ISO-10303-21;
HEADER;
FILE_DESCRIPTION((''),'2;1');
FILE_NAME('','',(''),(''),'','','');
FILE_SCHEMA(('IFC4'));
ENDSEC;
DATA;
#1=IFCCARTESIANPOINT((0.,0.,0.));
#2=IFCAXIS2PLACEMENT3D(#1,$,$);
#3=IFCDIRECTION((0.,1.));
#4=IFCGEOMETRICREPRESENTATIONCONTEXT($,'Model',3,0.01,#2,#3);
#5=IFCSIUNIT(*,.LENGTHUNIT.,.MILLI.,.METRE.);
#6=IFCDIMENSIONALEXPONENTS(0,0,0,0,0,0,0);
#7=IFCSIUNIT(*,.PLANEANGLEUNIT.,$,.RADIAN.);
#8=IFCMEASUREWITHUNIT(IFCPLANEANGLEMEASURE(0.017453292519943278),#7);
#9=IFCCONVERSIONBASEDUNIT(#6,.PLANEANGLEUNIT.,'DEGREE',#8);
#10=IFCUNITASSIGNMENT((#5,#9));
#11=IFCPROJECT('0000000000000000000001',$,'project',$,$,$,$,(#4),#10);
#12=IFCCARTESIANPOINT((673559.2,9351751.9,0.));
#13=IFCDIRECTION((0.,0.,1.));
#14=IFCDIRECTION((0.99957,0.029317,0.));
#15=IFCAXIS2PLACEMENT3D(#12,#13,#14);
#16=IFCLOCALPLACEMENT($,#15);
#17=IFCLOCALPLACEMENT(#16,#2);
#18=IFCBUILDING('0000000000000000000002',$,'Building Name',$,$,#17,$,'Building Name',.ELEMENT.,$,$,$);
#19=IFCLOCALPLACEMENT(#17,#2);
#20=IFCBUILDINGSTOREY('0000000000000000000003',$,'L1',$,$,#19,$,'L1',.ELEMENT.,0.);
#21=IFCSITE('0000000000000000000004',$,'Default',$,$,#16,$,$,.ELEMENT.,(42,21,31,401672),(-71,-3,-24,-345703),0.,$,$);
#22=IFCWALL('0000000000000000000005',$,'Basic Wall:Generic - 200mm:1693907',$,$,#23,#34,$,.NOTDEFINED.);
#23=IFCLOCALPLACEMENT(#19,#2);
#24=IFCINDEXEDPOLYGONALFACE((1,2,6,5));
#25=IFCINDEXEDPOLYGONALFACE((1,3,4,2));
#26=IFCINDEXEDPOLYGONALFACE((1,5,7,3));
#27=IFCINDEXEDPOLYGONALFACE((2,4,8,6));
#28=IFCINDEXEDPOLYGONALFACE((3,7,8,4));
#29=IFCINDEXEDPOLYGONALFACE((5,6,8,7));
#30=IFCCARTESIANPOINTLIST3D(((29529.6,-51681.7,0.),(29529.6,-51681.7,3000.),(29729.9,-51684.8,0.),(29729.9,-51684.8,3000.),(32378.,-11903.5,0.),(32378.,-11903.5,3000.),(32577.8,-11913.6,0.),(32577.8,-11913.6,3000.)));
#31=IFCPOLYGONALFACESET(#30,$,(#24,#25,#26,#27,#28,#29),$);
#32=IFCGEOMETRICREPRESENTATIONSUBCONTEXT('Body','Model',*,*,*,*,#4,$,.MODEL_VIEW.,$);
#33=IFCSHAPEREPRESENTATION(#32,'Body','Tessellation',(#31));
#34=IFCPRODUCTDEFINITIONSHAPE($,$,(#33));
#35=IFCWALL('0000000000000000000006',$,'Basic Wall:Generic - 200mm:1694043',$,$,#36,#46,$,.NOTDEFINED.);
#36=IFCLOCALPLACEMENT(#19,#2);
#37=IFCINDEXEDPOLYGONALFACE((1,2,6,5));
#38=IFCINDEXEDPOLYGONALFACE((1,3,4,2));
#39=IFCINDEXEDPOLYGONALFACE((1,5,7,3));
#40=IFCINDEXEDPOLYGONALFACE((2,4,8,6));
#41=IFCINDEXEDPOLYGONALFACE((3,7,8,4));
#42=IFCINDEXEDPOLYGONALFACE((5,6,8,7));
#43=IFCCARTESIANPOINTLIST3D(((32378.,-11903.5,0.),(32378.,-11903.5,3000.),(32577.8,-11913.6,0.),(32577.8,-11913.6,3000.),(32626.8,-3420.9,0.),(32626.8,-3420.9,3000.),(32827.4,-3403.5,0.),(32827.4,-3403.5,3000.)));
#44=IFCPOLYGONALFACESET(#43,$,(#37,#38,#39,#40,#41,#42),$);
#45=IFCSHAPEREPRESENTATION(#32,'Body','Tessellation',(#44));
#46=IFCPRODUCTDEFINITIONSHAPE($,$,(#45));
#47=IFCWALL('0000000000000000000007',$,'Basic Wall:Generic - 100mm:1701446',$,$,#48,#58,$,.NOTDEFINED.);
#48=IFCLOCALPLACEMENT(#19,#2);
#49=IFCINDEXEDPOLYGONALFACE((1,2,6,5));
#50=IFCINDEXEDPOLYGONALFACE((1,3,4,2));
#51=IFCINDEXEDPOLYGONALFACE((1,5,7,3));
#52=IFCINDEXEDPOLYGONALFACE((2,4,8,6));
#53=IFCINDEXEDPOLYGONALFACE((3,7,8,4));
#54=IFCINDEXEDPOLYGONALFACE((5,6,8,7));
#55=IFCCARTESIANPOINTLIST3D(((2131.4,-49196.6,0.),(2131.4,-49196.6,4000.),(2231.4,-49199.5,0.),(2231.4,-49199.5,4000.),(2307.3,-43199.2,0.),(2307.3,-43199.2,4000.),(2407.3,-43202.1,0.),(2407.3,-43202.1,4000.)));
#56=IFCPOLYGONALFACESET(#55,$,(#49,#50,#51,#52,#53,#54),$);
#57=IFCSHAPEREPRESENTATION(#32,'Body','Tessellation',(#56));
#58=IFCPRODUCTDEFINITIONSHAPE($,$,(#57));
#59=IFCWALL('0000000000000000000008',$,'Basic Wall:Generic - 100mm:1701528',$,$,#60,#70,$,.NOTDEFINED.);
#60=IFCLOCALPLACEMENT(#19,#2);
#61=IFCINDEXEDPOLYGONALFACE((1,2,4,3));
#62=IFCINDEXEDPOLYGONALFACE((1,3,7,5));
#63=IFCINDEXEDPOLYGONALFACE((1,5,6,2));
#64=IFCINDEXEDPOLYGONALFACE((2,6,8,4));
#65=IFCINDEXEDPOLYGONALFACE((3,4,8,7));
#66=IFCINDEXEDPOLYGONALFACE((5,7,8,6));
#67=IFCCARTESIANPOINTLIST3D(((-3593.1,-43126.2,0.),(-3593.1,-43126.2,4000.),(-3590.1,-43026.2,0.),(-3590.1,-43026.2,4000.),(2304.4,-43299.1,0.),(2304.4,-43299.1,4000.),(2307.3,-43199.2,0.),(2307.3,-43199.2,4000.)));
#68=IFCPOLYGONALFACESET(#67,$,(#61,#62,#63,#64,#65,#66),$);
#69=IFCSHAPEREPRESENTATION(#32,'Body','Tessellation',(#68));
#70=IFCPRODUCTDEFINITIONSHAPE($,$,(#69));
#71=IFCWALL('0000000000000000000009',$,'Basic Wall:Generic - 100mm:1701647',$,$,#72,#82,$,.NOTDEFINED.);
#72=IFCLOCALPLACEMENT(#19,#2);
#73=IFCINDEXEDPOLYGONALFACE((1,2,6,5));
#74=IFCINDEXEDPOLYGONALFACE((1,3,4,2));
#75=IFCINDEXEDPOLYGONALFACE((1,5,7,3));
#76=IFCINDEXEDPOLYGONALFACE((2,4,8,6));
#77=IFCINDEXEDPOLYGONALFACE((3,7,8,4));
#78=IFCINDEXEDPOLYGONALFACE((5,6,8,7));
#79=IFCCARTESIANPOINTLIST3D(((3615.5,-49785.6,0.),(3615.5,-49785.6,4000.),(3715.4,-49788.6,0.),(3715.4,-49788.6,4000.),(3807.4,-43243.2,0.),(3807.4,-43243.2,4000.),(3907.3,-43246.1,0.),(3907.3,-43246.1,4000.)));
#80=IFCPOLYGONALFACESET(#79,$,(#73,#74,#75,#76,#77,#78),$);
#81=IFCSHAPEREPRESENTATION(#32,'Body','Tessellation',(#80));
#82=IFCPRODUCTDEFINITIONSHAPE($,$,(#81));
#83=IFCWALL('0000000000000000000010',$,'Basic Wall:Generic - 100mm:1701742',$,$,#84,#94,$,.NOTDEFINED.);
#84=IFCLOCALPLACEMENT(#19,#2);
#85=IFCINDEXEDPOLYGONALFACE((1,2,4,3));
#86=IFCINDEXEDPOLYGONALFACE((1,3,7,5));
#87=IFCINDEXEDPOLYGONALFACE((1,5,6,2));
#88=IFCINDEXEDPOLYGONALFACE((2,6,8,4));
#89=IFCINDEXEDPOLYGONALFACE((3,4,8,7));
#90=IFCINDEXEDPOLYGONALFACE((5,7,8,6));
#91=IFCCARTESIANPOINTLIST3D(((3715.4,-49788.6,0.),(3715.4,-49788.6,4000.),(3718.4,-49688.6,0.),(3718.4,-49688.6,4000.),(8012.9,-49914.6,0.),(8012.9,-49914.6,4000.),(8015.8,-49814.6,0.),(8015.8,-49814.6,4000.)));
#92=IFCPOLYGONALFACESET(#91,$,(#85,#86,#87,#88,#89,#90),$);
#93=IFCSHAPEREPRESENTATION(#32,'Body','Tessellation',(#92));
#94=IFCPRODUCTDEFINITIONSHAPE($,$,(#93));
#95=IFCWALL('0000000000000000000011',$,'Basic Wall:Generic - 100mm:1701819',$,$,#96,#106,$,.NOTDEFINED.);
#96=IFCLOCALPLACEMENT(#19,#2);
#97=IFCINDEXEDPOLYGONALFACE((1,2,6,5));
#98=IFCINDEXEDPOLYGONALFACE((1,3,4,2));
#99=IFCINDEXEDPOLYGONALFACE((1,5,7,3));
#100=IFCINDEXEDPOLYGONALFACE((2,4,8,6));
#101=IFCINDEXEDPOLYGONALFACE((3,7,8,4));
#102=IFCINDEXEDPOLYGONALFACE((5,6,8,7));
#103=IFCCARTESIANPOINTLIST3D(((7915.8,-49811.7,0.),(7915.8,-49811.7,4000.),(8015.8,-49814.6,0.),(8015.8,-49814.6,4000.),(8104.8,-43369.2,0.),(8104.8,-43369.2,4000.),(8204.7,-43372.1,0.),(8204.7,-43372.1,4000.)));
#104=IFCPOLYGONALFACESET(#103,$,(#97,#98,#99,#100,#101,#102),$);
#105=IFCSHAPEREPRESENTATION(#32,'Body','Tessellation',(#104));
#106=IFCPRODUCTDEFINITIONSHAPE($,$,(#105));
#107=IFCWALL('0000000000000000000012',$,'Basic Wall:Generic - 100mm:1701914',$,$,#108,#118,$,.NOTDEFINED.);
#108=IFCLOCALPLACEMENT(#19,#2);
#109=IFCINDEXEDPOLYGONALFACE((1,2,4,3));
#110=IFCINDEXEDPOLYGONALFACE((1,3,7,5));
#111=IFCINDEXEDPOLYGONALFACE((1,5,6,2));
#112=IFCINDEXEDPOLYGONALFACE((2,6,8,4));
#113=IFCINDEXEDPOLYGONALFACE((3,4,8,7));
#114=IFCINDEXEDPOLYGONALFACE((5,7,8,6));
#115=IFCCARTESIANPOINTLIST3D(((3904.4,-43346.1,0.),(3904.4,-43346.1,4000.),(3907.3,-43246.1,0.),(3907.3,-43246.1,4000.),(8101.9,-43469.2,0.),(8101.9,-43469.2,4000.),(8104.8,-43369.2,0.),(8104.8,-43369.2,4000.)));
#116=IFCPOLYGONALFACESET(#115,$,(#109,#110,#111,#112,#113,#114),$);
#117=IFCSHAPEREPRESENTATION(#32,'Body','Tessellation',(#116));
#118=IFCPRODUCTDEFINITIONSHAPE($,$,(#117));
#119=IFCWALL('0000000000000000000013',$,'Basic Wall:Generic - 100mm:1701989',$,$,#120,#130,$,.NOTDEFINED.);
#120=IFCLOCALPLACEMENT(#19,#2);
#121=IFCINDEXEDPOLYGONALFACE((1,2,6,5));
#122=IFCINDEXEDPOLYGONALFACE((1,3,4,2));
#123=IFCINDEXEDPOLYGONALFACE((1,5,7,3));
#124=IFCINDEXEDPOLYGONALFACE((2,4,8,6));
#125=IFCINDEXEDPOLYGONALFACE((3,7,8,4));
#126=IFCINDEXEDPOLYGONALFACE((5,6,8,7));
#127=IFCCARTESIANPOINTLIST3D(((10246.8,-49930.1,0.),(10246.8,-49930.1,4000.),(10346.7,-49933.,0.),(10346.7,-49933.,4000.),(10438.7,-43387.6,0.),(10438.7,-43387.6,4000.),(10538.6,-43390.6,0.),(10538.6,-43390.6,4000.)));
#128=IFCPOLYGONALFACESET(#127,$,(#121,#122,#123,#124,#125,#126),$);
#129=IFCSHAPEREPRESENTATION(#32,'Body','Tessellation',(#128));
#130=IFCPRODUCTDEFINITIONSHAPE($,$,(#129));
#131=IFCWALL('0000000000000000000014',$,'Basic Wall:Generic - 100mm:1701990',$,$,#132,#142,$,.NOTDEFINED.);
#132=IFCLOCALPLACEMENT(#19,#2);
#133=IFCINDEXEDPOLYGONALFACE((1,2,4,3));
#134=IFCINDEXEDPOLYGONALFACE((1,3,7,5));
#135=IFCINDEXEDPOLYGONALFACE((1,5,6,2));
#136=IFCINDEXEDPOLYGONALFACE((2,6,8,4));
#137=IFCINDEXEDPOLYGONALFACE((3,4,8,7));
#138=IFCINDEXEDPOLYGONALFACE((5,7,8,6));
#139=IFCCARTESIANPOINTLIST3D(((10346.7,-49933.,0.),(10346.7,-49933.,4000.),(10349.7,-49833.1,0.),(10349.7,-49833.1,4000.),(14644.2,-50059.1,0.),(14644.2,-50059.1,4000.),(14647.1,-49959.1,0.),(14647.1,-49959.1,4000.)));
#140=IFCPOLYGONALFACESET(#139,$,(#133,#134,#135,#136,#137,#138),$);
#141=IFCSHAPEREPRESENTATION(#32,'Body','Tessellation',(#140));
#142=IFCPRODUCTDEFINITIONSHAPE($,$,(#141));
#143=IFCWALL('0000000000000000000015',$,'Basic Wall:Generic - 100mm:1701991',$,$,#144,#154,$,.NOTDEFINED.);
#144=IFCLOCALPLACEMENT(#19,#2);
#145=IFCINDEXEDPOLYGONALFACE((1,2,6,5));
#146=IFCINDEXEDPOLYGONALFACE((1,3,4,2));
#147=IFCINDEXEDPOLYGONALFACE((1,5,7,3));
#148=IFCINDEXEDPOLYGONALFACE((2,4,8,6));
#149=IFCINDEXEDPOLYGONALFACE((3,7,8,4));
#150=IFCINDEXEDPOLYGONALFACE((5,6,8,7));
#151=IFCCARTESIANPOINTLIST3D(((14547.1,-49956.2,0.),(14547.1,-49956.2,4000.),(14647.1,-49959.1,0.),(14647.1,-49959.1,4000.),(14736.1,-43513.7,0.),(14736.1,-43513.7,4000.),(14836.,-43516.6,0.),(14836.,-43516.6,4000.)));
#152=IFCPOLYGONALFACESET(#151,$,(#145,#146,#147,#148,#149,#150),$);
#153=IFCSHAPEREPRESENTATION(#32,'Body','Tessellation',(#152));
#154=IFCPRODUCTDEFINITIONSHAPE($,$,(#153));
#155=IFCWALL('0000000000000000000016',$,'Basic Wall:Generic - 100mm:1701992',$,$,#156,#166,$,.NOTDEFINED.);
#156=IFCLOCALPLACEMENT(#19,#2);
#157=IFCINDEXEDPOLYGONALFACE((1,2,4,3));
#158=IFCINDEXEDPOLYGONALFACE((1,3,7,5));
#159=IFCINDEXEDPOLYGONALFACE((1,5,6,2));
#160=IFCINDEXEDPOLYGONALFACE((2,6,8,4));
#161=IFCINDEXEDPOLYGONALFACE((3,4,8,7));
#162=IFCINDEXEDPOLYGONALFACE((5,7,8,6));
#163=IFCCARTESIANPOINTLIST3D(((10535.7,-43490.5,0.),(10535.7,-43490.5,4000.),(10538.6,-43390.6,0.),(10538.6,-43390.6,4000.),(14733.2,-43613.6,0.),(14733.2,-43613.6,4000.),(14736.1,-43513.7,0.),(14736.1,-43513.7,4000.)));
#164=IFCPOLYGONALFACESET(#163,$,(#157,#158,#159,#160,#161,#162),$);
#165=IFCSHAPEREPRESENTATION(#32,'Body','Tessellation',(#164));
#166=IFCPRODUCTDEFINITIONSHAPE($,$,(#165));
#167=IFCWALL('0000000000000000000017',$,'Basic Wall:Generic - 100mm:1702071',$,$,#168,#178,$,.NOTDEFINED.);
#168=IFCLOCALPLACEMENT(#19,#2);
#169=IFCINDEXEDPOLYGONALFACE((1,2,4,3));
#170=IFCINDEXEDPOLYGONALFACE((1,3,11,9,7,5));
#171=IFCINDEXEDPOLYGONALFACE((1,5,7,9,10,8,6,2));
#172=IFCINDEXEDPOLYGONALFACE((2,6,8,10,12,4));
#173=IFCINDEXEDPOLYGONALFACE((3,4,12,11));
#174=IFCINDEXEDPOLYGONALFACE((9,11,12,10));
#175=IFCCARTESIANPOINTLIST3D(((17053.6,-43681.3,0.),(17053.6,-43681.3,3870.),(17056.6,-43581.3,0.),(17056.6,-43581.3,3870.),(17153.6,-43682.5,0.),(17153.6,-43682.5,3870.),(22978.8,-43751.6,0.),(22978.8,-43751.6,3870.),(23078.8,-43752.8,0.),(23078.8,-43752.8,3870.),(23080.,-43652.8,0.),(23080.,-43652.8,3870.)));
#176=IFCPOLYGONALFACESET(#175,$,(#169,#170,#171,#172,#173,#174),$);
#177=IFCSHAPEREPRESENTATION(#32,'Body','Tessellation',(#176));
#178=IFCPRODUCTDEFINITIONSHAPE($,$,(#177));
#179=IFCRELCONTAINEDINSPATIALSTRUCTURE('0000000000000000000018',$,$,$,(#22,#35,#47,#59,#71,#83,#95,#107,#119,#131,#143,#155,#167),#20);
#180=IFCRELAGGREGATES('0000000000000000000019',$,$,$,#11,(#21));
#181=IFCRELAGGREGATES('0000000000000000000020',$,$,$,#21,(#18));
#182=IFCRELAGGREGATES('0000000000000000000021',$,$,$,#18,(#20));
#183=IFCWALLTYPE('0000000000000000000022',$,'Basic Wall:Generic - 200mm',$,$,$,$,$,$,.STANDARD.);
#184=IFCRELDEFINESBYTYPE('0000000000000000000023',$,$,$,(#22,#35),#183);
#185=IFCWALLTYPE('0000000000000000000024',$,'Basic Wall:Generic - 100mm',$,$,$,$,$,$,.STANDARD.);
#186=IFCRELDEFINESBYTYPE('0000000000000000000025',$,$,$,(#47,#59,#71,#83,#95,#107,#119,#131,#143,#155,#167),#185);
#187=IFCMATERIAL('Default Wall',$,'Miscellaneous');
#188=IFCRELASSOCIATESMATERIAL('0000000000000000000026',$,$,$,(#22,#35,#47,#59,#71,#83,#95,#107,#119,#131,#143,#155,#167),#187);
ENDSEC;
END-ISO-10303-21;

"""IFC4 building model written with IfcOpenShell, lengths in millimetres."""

from ifc_helpers import new_model, entity, si_unit, converted_unit, direction, frame, origin, place, context, subcontext, project, spatial, indexed_curve, outline, extrude, material, type_object, element, save


model = new_model("IFC4")

# Units and contexts
model_context = context("Model", 3, precision=0.01, world=origin(), true_north=direction((0.0, 1.0)))
body_context = subcontext(model_context, "Body", "Model", "MODEL_VIEW")
ifc_project = project(units=[si_unit("LENGTHUNIT", "METRE", prefix="MILLI"), converted_unit("PLANEANGLEUNIT", "DEGREE", entity("IfcPlaneAngleMeasure", 0.017453292519943278), si_unit("PLANEANGLEUNIT", "RADIAN"), dimensions=[0, 0, 0, 0, 0, 0, 0])], contexts=[model_context])

# Site, building, storey
site_placement = place(None, frame((673559.2, 9351751.9, 0.0), z_axis=(0.0, 0.0, 1.0), x_axis=(0.99957, 0.029317, 0.0)))
site = spatial("IfcSite", under=ifc_project, at=site_placement, Name="Default", CompositionType="ELEMENT", RefLatitude=(42, 21, 31, 401672), RefLongitude=(-71, -3, -24, -345703), RefElevation=0.0)
building_placement = place(site_placement, origin())
building = spatial("IfcBuilding", under=site, at=building_placement, Name="Building Name", LongName="Building Name", CompositionType="ELEMENT")
storey_placement = place(building_placement, origin())
storey = spatial("IfcBuildingStorey", under=building, at=storey_placement, Name="L1", LongName="L1", CompositionType="ELEMENT", Elevation=0.0)

# Walls
ifc_material = material(Name="Default Wall", Category="Miscellaneous")
wall_type_1 = type_object("IfcWallType", Name="Basic Wall:Generic - 200mm", PredefinedType="STANDARD")
wall_1_placement = place(storey_placement, frame((29629.4, -51688.8, 0.0), z_axis=(0.0, 0.0, 1.0), x_axis=(0.071424, 0.997446, 0.0)))
element("IfcWall", 1, at=wall_1_placement, inside=storey, type_object=wall_type_1, material=ifc_material, Name="Basic Wall:Generic - 200mm:1693907", PredefinedType="NOTDEFINED", context=body_context, shape_type="SweptSolid", body=[
    extrude(outline(indexed_curve([(39884.2, -100.0), (39880.0, 100.0), (0.0, 100.0), (11.2, -100.0), (39884.2, -100.0)], self_intersect=False)), origin(), (0.0, 0.0, 1.0), 3000.0),
])
wall_2_placement = place(storey_placement, frame((32477.9, -11910.6, 0.0), z_axis=(0.0, 0.0, 1.0), x_axis=(0.029317, 0.99957, 0.0)))
element("IfcWall", 2, at=wall_2_placement, inside=storey, type_object=wall_type_1, material=ifc_material, Name="Basic Wall:Generic - 200mm:1694043", PredefinedType="NOTDEFINED", context=body_context, shape_type="SweptSolid", body=[
    extrude(outline(indexed_curve([(8513.7, -100.0), (8490.5, 100.0), (4.2, 100.0), (0.0, -100.0), (8513.7, -100.0)], self_intersect=False)), origin(), (0.0, 0.0, 1.0), 3000.0),
])
wall_type_2 = type_object("IfcWallType", Name="Basic Wall:Generic - 100mm", PredefinedType="STANDARD")
wall_3_placement = place(storey_placement, frame((2181.4, -49198.1, 0.0), z_axis=(0.0, 0.0, 1.0), x_axis=(0.029317, 0.99957, 0.0)))
element("IfcWall", 3, at=wall_3_placement, inside=storey, type_object=wall_type_2, material=ifc_material, Name="Basic Wall:Generic - 100mm:1701446", PredefinedType="NOTDEFINED", context=body_context, shape_type="SweptSolid", body=[
    extrude(outline(indexed_curve([(6000.0, 50.0), (0.0, 50.0), (0.0, -50.0), (6000.0, -50.0), (6000.0, 50.0)], self_intersect=False)), origin(), (0.0, 0.0, 1.0), 4000.0),
])
wall_4_placement = place(storey_placement, frame((2305.8, -43249.2, 0.0), z_axis=(0.0, 0.0, 1.0), x_axis=(-0.99957, 0.029317, 0.0)))
element("IfcWall", 4, at=wall_4_placement, inside=storey, type_object=wall_type_2, material=ifc_material, Name="Basic Wall:Generic - 100mm:1701528", PredefinedType="NOTDEFINED", context=body_context, shape_type="SweptSolid", body=[
    extrude(outline(indexed_curve([(5900.0, 50.0), (0.0, 50.0), (0.0, -50.0), (5900.0, -50.0), (5900.0, 50.0)], self_intersect=False)), origin(), (0.0, 0.0, 1.0), 4000.0),
])
wall_5_placement = place(storey_placement, frame((3857.3, -43244.6, 0.0), z_axis=(0.0, 0.0, 1.0), x_axis=(-0.029317, -0.99957, 0.0)))
element("IfcWall", 5, at=wall_5_placement, inside=storey, type_object=wall_type_2, material=ifc_material, Name="Basic Wall:Generic - 100mm:1701647", PredefinedType="NOTDEFINED", context=body_context, shape_type="SweptSolid", body=[
    extrude(outline(indexed_curve([(6545.3, 50.0), (0.0, 50.0), (0.0, -50.0), (6545.3, -50.0), (6545.3, 50.0)], self_intersect=False)), origin(), (0.0, 0.0, 1.0), 4000.0),
])
wall_6_placement = place(storey_placement, frame((3716.9, -49738.6, 0.0), z_axis=(0.0, 0.0, 1.0), x_axis=(0.99957, -0.029317, 0.0)))
element("IfcWall", 6, at=wall_6_placement, inside=storey, type_object=wall_type_2, material=ifc_material, Name="Basic Wall:Generic - 100mm:1701742", PredefinedType="NOTDEFINED", context=body_context, shape_type="SweptSolid", body=[
    extrude(outline(indexed_curve([(4299.3, 50.0), (0.0, 50.0), (0.0, -50.0), (4299.3, -50.0), (4299.3, 50.0)], self_intersect=False)), origin(), (0.0, 0.0, 1.0), 4000.0),
])
wall_7_placement = place(storey_placement, frame((7965.8, -49813.2, 0.0), z_axis=(0.0, 0.0, 1.0), x_axis=(0.029317, 0.99957, 0.0)))
element("IfcWall", 7, at=wall_7_placement, inside=storey, type_object=wall_type_2, material=ifc_material, Name="Basic Wall:Generic - 100mm:1701819", PredefinedType="NOTDEFINED", context=body_context, shape_type="SweptSolid", body=[
    extrude(outline(indexed_curve([(6445.3, 50.0), (0.0, 50.0), (0.0, -50.0), (6445.3, -50.0), (6445.3, 50.0)], self_intersect=False)), origin(), (0.0, 0.0, 1.0), 4000.0),
])
wall_8_placement = place(storey_placement, frame((8103.3, -43419.2, 0.0), z_axis=(0.0, 0.0, 1.0), x_axis=(-0.99957, 0.029317, 0.0)))
element("IfcWall", 8, at=wall_8_placement, inside=storey, type_object=wall_type_2, material=ifc_material, Name="Basic Wall:Generic - 100mm:1701914", PredefinedType="NOTDEFINED", context=body_context, shape_type="SweptSolid", body=[
    extrude(outline(indexed_curve([(4199.3, 50.0), (0.0, 50.0), (0.0, -50.0), (4199.3, -50.0), (4199.3, 50.0)], self_intersect=False)), origin(), (0.0, 0.0, 1.0), 4000.0),
])
wall_9_placement = place(storey_placement, frame((10488.6, -43389.1, 0.0), z_axis=(0.0, 0.0, 1.0), x_axis=(-0.029317, -0.99957, 0.0)))
element("IfcWall", 9, at=wall_9_placement, inside=storey, type_object=wall_type_2, material=ifc_material, Name="Basic Wall:Generic - 100mm:1701989", PredefinedType="NOTDEFINED", context=body_context, shape_type="SweptSolid", body=[
    extrude(outline(indexed_curve([(6545.3, 50.0), (0.0, 50.0), (0.0, -50.0), (6545.3, -50.0), (6545.3, 50.0)], self_intersect=False)), origin(), (0.0, 0.0, 1.0), 4000.0),
])
wall_10_placement = place(storey_placement, frame((10348.2, -49883.1, 0.0), z_axis=(0.0, 0.0, 1.0), x_axis=(0.99957, -0.029317, 0.0)))
element("IfcWall", 10, at=wall_10_placement, inside=storey, type_object=wall_type_2, material=ifc_material, Name="Basic Wall:Generic - 100mm:1701990", PredefinedType="NOTDEFINED", context=body_context, shape_type="SweptSolid", body=[
    extrude(outline(indexed_curve([(4299.3, 50.0), (0.0, 50.0), (0.0, -50.0), (4299.3, -50.0), (4299.3, 50.0)], self_intersect=False)), origin(), (0.0, 0.0, 1.0), 4000.0),
])
wall_11_placement = place(storey_placement, frame((14597.1, -49957.7, 0.0), z_axis=(0.0, 0.0, 1.0), x_axis=(0.029317, 0.99957, 0.0)))
element("IfcWall", 11, at=wall_11_placement, inside=storey, type_object=wall_type_2, material=ifc_material, Name="Basic Wall:Generic - 100mm:1701991", PredefinedType="NOTDEFINED", context=body_context, shape_type="SweptSolid", body=[
    extrude(outline(indexed_curve([(6445.3, 50.0), (0.0, 50.0), (0.0, -50.0), (6445.3, -50.0), (6445.3, 50.0)], self_intersect=False)), origin(), (0.0, 0.0, 1.0), 4000.0),
])
wall_12_placement = place(storey_placement, frame((14734.6, -43563.7, 0.0), z_axis=(0.0, 0.0, 1.0), x_axis=(-0.99957, 0.029317, 0.0)))
element("IfcWall", 12, at=wall_12_placement, inside=storey, type_object=wall_type_2, material=ifc_material, Name="Basic Wall:Generic - 100mm:1701992", PredefinedType="NOTDEFINED", context=body_context, shape_type="SweptSolid", body=[
    extrude(outline(indexed_curve([(4199.3, 50.0), (0.0, 50.0), (0.0, -50.0), (4199.3, -50.0), (4199.3, 50.0)], self_intersect=False)), origin(), (0.0, 0.0, 1.0), 4000.0),
])
wall_13_placement = place(storey_placement, frame((17054.2, -43631.3, 0.0), z_axis=(0.0, 0.0, 1.0), x_axis=(0.99993, -0.011868, 0.0)))
element("IfcWall", 13, at=wall_13_placement, inside=storey, type_object=wall_type_2, material=ifc_material, Name="Basic Wall:Generic - 100mm:1702071", PredefinedType="NOTDEFINED", context=body_context, shape_type="SweptSolid", body=[
    extrude(outline(indexed_curve([(6025.6, -50.0), (6025.6, 50.0), (1.7, 50.0), (0.0, -50.0), (100.0, -50.0), (5925.6, -50.0), (6025.6, -50.0)], self_intersect=False)), origin(), (0.0, 0.0, 1.0), 3870.0),
])

save(model, "model.ifc")
